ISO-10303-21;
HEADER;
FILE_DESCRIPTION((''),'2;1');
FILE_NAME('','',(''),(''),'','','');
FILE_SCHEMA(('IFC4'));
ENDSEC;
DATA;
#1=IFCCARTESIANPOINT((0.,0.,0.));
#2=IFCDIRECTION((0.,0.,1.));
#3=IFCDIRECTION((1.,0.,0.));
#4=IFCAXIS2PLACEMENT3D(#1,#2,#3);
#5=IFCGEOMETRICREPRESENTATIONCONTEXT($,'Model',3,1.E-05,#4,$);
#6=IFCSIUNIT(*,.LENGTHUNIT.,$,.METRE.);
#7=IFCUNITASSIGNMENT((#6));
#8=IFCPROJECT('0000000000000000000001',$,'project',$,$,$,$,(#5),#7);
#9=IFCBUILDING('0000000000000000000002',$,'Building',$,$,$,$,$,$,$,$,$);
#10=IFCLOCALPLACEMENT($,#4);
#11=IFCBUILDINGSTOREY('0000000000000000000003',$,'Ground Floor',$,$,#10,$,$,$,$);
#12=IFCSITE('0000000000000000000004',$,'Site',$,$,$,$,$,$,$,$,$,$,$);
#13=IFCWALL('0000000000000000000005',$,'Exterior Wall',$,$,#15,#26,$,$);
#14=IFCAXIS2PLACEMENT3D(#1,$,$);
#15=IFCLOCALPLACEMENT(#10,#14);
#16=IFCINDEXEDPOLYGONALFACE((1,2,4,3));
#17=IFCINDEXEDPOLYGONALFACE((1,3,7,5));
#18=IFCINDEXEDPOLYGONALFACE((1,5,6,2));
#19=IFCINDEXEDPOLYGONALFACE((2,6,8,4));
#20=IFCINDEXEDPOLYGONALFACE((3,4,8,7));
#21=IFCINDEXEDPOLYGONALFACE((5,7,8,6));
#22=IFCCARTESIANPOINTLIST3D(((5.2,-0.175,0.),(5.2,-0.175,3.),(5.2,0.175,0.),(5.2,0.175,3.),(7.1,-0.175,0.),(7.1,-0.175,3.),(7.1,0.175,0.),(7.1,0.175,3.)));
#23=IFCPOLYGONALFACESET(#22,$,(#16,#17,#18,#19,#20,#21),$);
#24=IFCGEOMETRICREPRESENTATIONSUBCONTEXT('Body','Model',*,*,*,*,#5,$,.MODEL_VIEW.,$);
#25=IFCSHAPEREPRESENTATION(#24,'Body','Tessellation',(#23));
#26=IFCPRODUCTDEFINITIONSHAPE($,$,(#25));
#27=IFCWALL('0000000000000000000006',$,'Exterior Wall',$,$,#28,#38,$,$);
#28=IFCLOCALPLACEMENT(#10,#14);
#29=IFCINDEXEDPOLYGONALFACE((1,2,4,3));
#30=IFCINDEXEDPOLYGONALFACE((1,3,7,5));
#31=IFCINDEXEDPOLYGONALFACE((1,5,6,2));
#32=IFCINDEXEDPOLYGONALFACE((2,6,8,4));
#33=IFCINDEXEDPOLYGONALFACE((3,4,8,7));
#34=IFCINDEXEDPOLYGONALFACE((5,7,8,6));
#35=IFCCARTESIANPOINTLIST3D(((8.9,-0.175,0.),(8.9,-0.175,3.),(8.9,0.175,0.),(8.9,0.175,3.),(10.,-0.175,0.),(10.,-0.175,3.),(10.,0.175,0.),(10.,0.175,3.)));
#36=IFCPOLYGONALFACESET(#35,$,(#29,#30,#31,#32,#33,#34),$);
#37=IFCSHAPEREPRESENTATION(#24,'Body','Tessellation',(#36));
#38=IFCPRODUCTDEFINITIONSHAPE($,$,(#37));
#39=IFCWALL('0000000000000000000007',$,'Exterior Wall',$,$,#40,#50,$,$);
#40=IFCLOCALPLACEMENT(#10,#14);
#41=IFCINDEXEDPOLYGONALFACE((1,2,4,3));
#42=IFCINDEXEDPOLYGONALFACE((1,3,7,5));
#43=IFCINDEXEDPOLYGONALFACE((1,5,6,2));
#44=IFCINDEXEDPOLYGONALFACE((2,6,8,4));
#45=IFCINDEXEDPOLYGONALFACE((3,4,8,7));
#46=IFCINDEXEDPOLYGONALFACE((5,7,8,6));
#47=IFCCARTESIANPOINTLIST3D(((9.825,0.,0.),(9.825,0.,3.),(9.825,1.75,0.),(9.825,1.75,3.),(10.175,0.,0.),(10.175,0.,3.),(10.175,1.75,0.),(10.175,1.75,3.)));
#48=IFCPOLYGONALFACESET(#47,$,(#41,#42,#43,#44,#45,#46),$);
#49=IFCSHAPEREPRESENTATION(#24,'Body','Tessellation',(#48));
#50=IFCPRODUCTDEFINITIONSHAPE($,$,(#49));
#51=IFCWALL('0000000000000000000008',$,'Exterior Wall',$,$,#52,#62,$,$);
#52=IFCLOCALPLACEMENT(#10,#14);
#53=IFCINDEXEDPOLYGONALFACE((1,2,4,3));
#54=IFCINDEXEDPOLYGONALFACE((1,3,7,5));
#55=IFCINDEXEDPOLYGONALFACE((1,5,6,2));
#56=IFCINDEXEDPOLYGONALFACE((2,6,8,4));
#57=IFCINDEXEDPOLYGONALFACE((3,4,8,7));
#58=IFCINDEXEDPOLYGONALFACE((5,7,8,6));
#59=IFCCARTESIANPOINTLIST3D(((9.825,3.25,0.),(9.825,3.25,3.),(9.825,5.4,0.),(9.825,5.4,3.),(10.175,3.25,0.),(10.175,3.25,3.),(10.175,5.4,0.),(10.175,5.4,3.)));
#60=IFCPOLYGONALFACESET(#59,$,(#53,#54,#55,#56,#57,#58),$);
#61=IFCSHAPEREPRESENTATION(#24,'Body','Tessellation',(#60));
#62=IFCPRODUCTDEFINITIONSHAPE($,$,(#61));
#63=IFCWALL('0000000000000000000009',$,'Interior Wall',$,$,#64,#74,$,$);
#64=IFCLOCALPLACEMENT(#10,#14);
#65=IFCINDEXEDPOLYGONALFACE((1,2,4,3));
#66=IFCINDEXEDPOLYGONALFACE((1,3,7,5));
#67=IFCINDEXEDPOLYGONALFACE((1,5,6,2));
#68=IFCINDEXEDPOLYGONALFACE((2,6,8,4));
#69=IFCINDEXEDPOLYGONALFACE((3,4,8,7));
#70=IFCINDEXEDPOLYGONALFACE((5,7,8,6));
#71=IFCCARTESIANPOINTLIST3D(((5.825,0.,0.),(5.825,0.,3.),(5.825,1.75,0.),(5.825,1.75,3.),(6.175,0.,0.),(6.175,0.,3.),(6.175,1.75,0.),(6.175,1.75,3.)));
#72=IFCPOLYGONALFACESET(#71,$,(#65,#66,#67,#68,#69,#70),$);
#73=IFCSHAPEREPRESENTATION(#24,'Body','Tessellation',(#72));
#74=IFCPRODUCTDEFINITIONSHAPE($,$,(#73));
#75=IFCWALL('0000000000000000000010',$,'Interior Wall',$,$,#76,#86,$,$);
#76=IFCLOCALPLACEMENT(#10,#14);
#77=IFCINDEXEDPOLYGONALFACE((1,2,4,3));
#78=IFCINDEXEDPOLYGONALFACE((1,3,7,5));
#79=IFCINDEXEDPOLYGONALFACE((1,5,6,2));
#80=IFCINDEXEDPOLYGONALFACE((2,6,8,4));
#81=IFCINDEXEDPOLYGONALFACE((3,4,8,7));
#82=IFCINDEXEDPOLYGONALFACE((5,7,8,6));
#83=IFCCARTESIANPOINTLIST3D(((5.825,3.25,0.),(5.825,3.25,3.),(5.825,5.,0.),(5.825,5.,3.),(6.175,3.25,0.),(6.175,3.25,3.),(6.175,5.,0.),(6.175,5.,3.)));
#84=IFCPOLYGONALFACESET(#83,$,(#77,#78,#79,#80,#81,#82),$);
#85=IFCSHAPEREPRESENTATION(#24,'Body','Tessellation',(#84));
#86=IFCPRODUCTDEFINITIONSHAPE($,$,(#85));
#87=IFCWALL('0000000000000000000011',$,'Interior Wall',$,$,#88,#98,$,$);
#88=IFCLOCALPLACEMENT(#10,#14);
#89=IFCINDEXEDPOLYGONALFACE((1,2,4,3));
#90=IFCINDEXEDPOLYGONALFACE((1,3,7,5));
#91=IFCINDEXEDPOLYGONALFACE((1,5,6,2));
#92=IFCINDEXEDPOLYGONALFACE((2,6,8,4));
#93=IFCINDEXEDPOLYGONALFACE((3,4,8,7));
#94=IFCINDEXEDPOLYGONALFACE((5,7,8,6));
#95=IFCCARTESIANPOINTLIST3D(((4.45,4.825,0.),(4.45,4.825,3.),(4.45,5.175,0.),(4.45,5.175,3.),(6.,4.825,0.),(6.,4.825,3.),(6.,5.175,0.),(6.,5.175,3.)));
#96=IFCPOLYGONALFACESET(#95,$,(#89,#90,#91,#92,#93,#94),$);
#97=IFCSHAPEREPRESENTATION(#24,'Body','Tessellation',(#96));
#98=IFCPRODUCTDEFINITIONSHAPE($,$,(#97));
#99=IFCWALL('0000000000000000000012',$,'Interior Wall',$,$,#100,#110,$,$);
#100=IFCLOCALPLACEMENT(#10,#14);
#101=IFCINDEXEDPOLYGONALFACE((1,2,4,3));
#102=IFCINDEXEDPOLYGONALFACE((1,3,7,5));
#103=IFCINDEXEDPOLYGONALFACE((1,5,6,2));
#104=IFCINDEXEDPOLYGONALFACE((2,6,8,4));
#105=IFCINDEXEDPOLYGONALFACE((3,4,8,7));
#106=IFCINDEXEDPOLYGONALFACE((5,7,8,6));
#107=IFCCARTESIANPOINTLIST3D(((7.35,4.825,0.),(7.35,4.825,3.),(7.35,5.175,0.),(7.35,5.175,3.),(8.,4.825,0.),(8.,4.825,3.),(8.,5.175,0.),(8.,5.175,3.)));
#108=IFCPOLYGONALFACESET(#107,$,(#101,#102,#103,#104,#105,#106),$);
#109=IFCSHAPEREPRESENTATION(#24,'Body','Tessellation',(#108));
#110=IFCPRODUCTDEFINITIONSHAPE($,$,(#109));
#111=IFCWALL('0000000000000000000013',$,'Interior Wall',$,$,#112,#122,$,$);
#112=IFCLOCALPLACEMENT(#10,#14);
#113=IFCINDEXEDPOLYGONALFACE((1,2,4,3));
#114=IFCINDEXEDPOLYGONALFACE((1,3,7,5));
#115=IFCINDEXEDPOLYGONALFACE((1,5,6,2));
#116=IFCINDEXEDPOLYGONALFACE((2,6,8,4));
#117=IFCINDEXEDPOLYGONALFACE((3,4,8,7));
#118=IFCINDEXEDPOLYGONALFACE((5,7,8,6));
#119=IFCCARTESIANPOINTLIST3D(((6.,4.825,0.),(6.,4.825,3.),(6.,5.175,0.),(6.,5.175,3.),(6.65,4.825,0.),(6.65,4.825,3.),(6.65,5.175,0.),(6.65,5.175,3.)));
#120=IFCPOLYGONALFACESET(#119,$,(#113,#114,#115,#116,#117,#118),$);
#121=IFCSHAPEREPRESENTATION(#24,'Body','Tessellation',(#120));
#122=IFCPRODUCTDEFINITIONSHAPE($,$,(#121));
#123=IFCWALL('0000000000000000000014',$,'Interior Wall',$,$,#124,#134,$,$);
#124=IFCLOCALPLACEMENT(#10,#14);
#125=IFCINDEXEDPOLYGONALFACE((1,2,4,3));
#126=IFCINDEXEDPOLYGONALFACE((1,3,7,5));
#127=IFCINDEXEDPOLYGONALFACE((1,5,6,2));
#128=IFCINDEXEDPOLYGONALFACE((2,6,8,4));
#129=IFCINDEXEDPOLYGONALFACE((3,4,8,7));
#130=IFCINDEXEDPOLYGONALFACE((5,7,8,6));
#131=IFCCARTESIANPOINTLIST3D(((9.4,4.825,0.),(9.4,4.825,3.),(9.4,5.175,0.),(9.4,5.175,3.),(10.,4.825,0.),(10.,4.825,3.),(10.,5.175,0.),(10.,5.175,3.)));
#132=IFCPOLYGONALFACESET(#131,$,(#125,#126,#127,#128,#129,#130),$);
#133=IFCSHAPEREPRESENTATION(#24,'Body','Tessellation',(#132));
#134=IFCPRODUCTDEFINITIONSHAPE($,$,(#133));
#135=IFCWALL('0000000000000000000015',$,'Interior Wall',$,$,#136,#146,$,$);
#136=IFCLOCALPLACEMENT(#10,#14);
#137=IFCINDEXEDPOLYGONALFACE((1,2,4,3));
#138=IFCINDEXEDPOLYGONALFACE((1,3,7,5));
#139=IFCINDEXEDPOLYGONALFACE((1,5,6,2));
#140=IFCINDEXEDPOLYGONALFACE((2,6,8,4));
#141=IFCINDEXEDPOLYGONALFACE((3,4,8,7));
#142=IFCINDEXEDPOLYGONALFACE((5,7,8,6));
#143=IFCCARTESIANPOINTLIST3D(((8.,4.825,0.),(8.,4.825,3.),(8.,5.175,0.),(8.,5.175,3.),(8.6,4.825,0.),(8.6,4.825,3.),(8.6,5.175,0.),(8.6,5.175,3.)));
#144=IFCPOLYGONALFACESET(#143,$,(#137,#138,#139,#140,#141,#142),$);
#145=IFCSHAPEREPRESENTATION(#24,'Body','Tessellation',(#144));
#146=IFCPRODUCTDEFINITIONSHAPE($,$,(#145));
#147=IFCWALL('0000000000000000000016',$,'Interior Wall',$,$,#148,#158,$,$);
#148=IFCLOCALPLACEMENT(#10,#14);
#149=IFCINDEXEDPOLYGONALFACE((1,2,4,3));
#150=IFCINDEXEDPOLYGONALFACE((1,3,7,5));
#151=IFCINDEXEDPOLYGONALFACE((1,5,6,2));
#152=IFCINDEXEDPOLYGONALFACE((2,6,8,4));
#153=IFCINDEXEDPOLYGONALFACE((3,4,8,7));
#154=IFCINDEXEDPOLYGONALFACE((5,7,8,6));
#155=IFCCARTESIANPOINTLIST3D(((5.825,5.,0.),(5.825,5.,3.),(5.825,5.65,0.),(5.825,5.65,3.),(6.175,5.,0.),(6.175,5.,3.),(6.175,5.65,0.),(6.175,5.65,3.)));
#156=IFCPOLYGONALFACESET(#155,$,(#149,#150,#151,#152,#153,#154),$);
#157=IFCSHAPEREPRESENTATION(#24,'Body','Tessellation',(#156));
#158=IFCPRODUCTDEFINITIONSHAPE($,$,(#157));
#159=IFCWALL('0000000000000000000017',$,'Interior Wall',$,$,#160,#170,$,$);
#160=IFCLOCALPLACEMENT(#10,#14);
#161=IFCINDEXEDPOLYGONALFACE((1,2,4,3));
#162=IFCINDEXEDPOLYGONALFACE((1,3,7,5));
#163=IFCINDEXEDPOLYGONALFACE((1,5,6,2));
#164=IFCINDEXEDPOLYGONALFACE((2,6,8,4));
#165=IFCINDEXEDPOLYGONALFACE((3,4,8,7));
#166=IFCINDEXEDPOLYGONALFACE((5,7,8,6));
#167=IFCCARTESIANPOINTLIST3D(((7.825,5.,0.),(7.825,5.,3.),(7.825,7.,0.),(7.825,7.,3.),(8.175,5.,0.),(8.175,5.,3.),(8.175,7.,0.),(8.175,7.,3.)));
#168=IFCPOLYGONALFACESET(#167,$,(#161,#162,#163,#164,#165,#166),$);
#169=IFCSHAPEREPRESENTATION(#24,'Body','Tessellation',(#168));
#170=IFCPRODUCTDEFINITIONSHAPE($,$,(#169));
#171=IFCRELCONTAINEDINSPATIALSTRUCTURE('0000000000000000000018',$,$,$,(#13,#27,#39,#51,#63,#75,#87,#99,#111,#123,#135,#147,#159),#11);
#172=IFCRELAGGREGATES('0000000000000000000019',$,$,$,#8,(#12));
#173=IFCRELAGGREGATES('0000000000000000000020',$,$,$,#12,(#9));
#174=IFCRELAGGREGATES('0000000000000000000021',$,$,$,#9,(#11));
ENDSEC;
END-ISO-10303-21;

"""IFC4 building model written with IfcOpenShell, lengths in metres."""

from ifc_helpers import new_model, si_unit, frame, origin_with_axes, place, context, subcontext, project, spatial, indexed_curve, outline, extrude, element, save


model = new_model("IFC4")

# Units and contexts
model_context = context("Model", 3, precision=1e-05, world=origin_with_axes())
body_context = subcontext(model_context, "Body", "Model", "MODEL_VIEW")
ifc_project = project(units=[si_unit("LENGTHUNIT", "METRE")], contexts=[model_context])

# Site, building, storey
site = spatial("IfcSite", under=ifc_project, Name="Site")
building = spatial("IfcBuilding", under=site, Name="Building")
storey_placement = place(None, origin_with_axes())
storey = spatial("IfcBuildingStorey", under=building, at=storey_placement, Name="Ground Floor")

# Walls
wall_1_placement = place(storey_placement, frame((5.2, 0.0, 0.0), z_axis=(0.0, 0.0, 1.0), x_axis=(1.0, 0.0, 0.0)))
element("IfcWall", 1, at=wall_1_placement, inside=storey, Name="Exterior Wall", context=body_context, shape_type="SweptSolid", body=[
    extrude(outline(indexed_curve([(0.0, 0.0), (0.0, 0.35), (1.9, 0.35), (1.9, 0.0), (0.0, 0.0)], self_intersect=False)), frame((0.0, -0.175, 0.0), z_axis=(0.0, 0.0, 1.0), x_axis=(1.0, 0.0, 0.0)), (0.0, 0.0, 1.0), 3.0),
])
wall_2_placement = place(storey_placement, frame((8.9, 0.0, 0.0), z_axis=(0.0, 0.0, 1.0), x_axis=(1.0, 0.0, 0.0)))
element("IfcWall", 2, at=wall_2_placement, inside=storey, Name="Exterior Wall", context=body_context, shape_type="SweptSolid", body=[
    extrude(outline(indexed_curve([(0.0, 0.0), (0.0, 0.35), (1.1, 0.35), (1.1, 0.0), (0.0, 0.0)], self_intersect=False)), frame((0.0, -0.175, 0.0), z_axis=(0.0, 0.0, 1.0), x_axis=(1.0, 0.0, 0.0)), (0.0, 0.0, 1.0), 3.0),
])
wall_3_placement = place(storey_placement, frame((10.0, 0.0, 0.0), z_axis=(0.0, 0.0, 1.0), x_axis=(0.0, 1.0, 0.0)))
element("IfcWall", 3, at=wall_3_placement, inside=storey, Name="Exterior Wall", context=body_context, shape_type="SweptSolid", body=[
    extrude(outline(indexed_curve([(0.0, 0.0), (0.0, 0.35), (1.75, 0.35), (1.75, 0.0), (0.0, 0.0)], self_intersect=False)), frame((0.0, -0.175, 0.0), z_axis=(0.0, 0.0, 1.0), x_axis=(1.0, 0.0, 0.0)), (0.0, 0.0, 1.0), 3.0),
])
wall_4_placement = place(storey_placement, frame((10.0, 3.25, 0.0), z_axis=(0.0, 0.0, 1.0), x_axis=(0.0, 1.0, 0.0)))
element("IfcWall", 4, at=wall_4_placement, inside=storey, Name="Exterior Wall", context=body_context, shape_type="SweptSolid", body=[
    extrude(outline(indexed_curve([(0.0, 0.0), (0.0, 0.35), (2.15, 0.35), (2.15, 0.0), (0.0, 0.0)], self_intersect=False)), frame((0.0, -0.175, 0.0), z_axis=(0.0, 0.0, 1.0), x_axis=(1.0, 0.0, 0.0)), (0.0, 0.0, 1.0), 3.0),
])
for number, where, z_axis, x_axis, name in (
    (5, (6.0, 0.0, 0.0), (0.0, 0.0, 1.0), (0.0, 1.0, 0.0), "Interior Wall"),
    (6, (6.0, 3.25, 0.0), (0.0, 0.0, 1.0), (0.0, 1.0, 0.0), "Interior Wall"),
):
    element("IfcWall", number, at=place(storey_placement, frame(where, z_axis=z_axis, x_axis=x_axis)), inside=storey, Name=name, context=body_context, shape_type="SweptSolid", body=[
        extrude(outline(indexed_curve([(0.0, 0.0), (0.0, 0.35), (1.75, 0.35), (1.75, 0.0), (0.0, 0.0)], self_intersect=False)), frame((0.0, -0.175, 0.0), z_axis=(0.0, 0.0, 1.0), x_axis=(1.0, 0.0, 0.0)), (0.0, 0.0, 1.0), 3.0),
    ])
wall_5_placement = place(storey_placement, frame((6.0, 5.0, 0.0), z_axis=(0.0, 0.0, 1.0), x_axis=(-1.0, 0.0, 0.0)))
element("IfcWall", 7, at=wall_5_placement, inside=storey, Name="Interior Wall", context=body_context, shape_type="SweptSolid", body=[
    extrude(outline(indexed_curve([(0.0, 0.0), (0.0, 0.35), (1.55, 0.35), (1.55, 0.0), (0.0, 0.0)], self_intersect=False)), frame((0.0, -0.175, 0.0), z_axis=(0.0, 0.0, 1.0), x_axis=(1.0, 0.0, 0.0)), (0.0, 0.0, 1.0), 3.0),
])
for number, where, z_axis, x_axis, name in (
    (8, (8.0, 5.0, 0.0), (0.0, 0.0, 1.0), (-1.0, 0.0, 0.0), "Interior Wall"),
    (9, (6.65, 5.0, 0.0), (0.0, 0.0, 1.0), (-1.0, 0.0, 0.0), "Interior Wall"),
):
    element("IfcWall", number, at=place(storey_placement, frame(where, z_axis=z_axis, x_axis=x_axis)), inside=storey, Name=name, context=body_context, shape_type="SweptSolid", body=[
        extrude(outline(indexed_curve([(0.0, 0.0), (0.0, 0.35), (0.65, 0.35), (0.65, 0.0), (0.0, 0.0)], self_intersect=False)), frame((0.0, -0.175, 0.0), z_axis=(0.0, 0.0, 1.0), x_axis=(1.0, 0.0, 0.0)), (0.0, 0.0, 1.0), 3.0),
    ])
for number, where, z_axis, x_axis, name in (
    (10, (10.0, 5.0, 0.0), (0.0, 0.0, 1.0), (-1.0, 0.0, 0.0), "Interior Wall"),
    (11, (8.6, 5.0, 0.0), (0.0, 0.0, 1.0), (-1.0, 0.0, 0.0), "Interior Wall"),
):
    element("IfcWall", number, at=place(storey_placement, frame(where, z_axis=z_axis, x_axis=x_axis)), inside=storey, Name=name, context=body_context, shape_type="SweptSolid", body=[
        extrude(outline(indexed_curve([(0.0, 0.0), (0.0, 0.35), (0.6, 0.35), (0.6, 0.0), (0.0, 0.0)], self_intersect=False)), frame((0.0, -0.175, 0.0), z_axis=(0.0, 0.0, 1.0), x_axis=(1.0, 0.0, 0.0)), (0.0, 0.0, 1.0), 3.0),
    ])
wall_6_placement = place(storey_placement, frame((6.0, 5.0, 0.0), z_axis=(0.0, 0.0, 1.0), x_axis=(0.0, 1.0, 0.0)))
element("IfcWall", 12, at=wall_6_placement, inside=storey, Name="Interior Wall", context=body_context, shape_type="SweptSolid", body=[
    extrude(outline(indexed_curve([(0.0, 0.0), (0.0, 0.35), (0.65, 0.35), (0.65, 0.0), (0.0, 0.0)], self_intersect=False)), frame((0.0, -0.175, 0.0), z_axis=(0.0, 0.0, 1.0), x_axis=(1.0, 0.0, 0.0)), (0.0, 0.0, 1.0), 3.0),
])
wall_7_placement = place(storey_placement, frame((8.0, 5.0, 0.0), z_axis=(0.0, 0.0, 1.0), x_axis=(0.0, 1.0, 0.0)))
element("IfcWall", 13, at=wall_7_placement, inside=storey, Name="Interior Wall", context=body_context, shape_type="SweptSolid", body=[
    extrude(outline(indexed_curve([(0.0, 0.0), (0.0, 0.35), (2.0, 0.35), (2.0, 0.0), (0.0, 0.0)], self_intersect=False)), frame((0.0, -0.175, 0.0), z_axis=(0.0, 0.0, 1.0), x_axis=(1.0, 0.0, 0.0)), (0.0, 0.0, 1.0), 3.0),
])

save(model, "model.ifc")
